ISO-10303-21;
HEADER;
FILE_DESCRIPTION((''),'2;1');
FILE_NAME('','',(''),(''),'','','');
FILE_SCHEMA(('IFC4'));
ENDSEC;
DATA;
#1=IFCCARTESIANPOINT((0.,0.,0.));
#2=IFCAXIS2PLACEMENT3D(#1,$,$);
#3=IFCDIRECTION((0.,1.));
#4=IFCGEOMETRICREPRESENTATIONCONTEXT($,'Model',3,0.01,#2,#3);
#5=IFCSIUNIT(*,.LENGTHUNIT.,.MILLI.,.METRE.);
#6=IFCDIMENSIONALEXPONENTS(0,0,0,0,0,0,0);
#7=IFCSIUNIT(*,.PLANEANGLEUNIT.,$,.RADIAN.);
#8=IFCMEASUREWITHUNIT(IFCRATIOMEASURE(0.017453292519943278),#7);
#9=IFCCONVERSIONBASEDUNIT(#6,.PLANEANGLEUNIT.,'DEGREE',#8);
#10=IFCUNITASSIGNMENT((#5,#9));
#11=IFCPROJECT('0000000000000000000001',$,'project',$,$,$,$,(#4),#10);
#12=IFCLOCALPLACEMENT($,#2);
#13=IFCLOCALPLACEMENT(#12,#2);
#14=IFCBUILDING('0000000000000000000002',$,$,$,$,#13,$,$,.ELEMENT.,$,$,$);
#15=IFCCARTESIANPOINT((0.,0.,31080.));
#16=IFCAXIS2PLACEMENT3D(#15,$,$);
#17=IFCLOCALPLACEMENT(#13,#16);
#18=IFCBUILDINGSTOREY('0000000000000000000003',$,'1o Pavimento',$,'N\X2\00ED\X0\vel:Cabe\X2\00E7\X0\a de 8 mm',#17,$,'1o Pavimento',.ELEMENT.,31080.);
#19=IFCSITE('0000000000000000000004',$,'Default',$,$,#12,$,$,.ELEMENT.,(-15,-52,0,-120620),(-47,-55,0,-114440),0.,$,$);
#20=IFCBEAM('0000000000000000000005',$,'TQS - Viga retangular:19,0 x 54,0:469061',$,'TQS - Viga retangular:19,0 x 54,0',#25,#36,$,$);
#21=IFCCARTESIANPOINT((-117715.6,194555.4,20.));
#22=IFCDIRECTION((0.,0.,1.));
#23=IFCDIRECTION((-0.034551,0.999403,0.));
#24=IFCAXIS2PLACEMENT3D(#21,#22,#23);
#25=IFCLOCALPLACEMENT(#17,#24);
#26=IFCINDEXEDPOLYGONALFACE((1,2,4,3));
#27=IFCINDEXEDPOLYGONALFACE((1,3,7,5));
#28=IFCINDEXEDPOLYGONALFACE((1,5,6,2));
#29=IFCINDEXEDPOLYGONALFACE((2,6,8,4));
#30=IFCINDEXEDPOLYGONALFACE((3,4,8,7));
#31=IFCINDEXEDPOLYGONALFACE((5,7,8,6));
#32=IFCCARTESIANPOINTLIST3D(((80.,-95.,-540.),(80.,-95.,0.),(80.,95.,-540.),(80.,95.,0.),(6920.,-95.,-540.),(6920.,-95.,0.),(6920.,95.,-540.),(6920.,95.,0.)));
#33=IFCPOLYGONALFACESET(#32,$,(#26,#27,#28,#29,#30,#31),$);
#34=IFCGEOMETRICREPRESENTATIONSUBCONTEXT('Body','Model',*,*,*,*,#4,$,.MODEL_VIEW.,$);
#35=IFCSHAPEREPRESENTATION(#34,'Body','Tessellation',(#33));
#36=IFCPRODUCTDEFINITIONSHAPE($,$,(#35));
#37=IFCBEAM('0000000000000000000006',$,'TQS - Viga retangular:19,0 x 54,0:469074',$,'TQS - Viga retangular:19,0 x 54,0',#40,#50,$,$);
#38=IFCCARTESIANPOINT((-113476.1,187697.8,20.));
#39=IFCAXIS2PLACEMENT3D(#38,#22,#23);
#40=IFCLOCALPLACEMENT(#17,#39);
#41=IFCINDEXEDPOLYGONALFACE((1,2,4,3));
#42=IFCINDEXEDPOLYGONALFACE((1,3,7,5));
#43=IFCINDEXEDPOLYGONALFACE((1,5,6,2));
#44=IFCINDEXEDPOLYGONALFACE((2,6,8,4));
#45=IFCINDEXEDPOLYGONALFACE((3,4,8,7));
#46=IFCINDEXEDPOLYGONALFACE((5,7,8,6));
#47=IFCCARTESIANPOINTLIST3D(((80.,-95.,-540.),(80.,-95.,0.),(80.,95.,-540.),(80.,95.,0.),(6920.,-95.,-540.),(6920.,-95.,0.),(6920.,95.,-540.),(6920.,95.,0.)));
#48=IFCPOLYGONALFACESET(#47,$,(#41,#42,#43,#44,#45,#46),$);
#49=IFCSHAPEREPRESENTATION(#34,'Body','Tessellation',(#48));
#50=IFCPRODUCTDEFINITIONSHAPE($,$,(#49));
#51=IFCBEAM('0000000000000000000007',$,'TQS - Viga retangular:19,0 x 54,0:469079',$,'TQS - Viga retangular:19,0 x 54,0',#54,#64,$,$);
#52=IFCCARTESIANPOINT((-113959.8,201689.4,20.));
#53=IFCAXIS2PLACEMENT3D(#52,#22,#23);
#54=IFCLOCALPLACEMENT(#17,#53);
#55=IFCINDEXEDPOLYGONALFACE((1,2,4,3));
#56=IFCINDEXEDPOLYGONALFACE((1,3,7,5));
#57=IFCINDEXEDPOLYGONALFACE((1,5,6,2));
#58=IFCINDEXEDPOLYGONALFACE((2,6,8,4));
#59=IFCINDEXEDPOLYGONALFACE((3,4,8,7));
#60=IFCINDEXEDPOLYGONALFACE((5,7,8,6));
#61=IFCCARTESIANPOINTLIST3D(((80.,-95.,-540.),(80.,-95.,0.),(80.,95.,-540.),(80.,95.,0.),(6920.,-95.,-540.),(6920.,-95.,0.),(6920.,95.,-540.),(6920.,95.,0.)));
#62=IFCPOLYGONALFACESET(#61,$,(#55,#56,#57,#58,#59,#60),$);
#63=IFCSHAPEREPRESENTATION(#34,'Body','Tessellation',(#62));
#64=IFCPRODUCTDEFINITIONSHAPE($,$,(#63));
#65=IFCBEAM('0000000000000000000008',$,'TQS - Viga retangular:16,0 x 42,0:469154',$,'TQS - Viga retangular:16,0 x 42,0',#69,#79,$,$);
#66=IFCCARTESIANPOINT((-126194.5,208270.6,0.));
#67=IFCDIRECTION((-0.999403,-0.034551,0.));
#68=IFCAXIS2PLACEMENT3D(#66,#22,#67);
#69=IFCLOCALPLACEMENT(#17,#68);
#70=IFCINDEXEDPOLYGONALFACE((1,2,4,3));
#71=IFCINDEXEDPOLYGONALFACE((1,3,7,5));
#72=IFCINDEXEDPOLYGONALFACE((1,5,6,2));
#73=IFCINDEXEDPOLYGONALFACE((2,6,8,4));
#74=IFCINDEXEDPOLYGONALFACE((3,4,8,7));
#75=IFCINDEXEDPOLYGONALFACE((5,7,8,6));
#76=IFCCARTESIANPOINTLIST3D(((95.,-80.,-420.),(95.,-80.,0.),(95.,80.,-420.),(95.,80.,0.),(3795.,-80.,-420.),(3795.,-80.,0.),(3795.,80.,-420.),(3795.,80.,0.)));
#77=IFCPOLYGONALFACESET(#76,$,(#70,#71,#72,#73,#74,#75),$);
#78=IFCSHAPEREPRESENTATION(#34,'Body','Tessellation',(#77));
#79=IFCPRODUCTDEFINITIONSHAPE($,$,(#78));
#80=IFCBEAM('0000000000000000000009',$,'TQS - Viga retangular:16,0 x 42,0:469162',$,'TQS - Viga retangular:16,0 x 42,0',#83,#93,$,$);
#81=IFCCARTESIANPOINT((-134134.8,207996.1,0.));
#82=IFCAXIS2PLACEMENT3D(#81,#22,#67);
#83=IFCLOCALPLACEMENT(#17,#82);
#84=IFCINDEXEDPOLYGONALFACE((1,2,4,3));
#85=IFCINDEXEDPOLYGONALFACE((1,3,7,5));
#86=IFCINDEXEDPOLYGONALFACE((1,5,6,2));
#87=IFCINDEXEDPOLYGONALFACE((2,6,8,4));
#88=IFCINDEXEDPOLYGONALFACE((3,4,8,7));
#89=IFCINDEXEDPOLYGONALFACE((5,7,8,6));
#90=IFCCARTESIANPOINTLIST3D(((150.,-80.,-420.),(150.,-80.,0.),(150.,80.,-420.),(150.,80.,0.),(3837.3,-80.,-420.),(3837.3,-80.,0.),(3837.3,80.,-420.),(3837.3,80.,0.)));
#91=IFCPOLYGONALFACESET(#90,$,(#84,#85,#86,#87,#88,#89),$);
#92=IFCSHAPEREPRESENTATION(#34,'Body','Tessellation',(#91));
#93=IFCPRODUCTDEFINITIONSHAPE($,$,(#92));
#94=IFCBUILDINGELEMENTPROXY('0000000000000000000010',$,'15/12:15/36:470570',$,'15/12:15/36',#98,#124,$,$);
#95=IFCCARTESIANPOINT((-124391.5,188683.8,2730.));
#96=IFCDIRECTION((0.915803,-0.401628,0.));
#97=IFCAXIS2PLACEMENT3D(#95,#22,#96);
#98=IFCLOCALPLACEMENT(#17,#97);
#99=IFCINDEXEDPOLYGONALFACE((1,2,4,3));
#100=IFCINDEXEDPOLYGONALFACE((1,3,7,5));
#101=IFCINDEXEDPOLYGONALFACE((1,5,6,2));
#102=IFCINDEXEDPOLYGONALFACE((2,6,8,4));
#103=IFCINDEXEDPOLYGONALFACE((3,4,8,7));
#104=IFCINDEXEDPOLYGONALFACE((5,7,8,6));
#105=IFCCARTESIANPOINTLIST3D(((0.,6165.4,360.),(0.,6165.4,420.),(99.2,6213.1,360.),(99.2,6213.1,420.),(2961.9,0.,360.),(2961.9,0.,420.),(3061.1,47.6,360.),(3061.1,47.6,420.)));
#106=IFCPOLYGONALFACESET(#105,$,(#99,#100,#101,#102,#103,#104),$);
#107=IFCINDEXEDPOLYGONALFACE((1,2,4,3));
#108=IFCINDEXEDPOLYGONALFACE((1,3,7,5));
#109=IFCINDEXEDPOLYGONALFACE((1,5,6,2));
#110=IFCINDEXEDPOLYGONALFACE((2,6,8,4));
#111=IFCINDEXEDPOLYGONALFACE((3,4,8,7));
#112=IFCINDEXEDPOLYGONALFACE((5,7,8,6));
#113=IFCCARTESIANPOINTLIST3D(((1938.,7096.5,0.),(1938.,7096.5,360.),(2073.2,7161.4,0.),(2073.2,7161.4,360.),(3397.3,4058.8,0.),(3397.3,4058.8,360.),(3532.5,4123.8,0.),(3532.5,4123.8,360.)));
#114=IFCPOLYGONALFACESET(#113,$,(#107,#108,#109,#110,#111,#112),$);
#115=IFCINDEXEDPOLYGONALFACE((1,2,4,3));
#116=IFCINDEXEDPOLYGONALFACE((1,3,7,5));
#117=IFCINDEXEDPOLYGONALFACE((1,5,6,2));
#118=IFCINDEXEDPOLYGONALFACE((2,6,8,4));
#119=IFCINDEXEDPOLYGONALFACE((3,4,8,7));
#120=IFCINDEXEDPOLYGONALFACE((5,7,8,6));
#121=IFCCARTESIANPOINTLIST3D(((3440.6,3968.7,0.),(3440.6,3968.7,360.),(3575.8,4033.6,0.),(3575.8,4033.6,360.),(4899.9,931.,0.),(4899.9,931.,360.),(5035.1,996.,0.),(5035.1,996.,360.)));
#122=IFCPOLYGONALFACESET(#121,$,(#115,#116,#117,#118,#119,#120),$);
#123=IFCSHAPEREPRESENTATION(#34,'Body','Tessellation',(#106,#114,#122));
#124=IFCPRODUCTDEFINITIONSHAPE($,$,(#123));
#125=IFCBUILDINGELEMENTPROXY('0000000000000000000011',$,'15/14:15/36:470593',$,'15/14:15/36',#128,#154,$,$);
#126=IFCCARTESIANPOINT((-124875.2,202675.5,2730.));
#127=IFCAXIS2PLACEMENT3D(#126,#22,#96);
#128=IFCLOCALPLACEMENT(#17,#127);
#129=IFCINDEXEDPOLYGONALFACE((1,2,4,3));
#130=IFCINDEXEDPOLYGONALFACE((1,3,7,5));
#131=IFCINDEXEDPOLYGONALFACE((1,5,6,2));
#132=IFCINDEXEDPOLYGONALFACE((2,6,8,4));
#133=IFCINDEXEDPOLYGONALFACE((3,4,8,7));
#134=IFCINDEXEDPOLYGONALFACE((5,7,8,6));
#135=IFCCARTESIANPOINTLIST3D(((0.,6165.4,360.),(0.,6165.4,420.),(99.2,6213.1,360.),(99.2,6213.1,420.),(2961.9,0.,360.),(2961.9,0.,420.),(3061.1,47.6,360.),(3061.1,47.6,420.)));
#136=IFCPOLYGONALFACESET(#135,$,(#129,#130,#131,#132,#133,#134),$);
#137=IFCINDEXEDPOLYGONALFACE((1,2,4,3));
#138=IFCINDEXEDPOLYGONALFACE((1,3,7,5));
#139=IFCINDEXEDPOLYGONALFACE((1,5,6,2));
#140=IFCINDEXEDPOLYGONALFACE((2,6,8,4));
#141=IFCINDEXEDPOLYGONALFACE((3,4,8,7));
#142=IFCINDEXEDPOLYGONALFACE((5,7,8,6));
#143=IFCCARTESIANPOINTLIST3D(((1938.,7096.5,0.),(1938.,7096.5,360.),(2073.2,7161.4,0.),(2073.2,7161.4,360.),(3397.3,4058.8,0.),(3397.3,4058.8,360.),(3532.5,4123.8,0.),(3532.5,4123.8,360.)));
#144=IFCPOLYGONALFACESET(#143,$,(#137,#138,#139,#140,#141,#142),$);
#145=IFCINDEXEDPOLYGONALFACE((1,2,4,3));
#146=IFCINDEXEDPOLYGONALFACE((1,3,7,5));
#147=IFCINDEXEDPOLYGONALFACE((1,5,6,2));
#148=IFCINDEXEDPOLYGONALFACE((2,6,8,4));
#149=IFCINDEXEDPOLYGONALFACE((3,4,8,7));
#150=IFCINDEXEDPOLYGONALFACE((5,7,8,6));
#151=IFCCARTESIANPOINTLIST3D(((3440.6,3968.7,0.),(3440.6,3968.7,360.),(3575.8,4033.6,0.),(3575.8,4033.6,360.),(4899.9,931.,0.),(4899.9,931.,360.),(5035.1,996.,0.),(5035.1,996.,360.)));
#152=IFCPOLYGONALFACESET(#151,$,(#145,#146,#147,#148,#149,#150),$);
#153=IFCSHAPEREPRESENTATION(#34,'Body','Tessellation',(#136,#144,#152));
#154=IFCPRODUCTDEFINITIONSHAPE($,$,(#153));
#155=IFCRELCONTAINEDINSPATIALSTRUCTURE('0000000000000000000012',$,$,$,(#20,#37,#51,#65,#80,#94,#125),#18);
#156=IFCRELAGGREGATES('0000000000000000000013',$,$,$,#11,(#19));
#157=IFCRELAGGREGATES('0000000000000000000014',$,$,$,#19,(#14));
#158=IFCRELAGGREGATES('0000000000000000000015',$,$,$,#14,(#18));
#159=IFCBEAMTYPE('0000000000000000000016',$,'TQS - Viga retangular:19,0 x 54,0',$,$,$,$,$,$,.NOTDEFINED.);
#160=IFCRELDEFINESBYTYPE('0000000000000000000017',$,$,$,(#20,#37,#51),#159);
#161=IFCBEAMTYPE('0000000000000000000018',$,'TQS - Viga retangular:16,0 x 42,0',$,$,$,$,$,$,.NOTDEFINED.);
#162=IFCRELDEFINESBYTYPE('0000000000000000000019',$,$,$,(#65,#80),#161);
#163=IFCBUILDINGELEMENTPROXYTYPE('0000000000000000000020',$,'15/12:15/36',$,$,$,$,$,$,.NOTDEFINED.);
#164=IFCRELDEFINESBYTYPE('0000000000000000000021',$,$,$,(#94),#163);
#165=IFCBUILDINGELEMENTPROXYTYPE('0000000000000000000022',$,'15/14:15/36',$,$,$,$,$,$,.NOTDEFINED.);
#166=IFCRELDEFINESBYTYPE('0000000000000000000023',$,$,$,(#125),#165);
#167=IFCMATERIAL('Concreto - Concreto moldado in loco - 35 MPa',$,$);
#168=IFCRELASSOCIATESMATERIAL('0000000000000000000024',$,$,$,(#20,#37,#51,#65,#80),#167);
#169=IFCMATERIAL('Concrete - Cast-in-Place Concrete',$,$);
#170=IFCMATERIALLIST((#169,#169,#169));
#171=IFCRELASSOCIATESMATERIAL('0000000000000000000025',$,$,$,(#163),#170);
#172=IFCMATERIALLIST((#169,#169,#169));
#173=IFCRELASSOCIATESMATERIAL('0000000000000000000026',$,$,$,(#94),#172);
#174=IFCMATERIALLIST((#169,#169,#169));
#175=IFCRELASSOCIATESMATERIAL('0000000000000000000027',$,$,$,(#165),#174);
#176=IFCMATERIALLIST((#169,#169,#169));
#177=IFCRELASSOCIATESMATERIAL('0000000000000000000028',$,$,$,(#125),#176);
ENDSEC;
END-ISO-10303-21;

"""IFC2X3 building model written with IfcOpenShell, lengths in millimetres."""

from ifc_helpers import new_model, entity, si_unit, converted_unit, direction, frame, frame_2d, origin, place, context, subcontext, project, spatial, rectangle, extrude, source, transform, mapped, material, material_list, type_object, type_shapes, element, save


model = new_model("IFC2X3")

# Units and contexts
model_context = context("Model", 3, precision=0.01, world=origin(), true_north=direction((0.0, 1.0)))
body_context = subcontext(model_context, "Body", "Model", "MODEL_VIEW")
ifc_project = project(units=[si_unit("LENGTHUNIT", "METRE", prefix="MILLI"), converted_unit("PLANEANGLEUNIT", "DEGREE", entity("IfcRatioMeasure", 0.017453292519943278), si_unit("PLANEANGLEUNIT", "RADIAN"), dimensions=[0, 0, 0, 0, 0, 0, 0])], contexts=[model_context])

# Site, building, storey
site_placement = place(None, origin())
site = spatial("IfcSite", under=ifc_project, at=site_placement, Name="Default", CompositionType="ELEMENT", RefLatitude=(-15, -52, 0, -120620), RefLongitude=(-47, -55, 0, -114440), RefElevation=0.0)
building_placement = place(site_placement, origin())
building = spatial("IfcBuilding", under=site, at=building_placement, CompositionType="ELEMENT")
storey_placement = place(building_placement, frame((0.0, 0.0, 31080.0)))
storey = spatial("IfcBuildingStorey", under=building, at=storey_placement, Name="1o Pavimento", ObjectType="Nível:Cabeça de 8 mm", LongName="1o Pavimento", CompositionType="ELEMENT", Elevation=31080.0)

# Beams
ifc_material_1 = material(Name="Concreto - Concreto moldado in loco - 35 MPa")
beam_type_1 = type_object("IfcBeamType", Name="TQS - Viga retangular:19,0 x 54,0", PredefinedType="NOTDEFINED")
beam_1_placement = place(storey_placement, frame((-117715.6, 194555.4, 20.0), z_axis=(0.0, 0.0, 1.0), x_axis=(-0.034551, 0.999403, 0.0)))
element("IfcBeam", 1, at=beam_1_placement, inside=storey, type_object=beam_type_1, material=ifc_material_1, Name="TQS - Viga retangular:19,0 x 54,0:469061", ObjectType="TQS - Viga retangular:19,0 x 54,0", context=body_context, shape_type="SweptSolid", body=[
    extrude(rectangle(XDim=540.0, YDim=190.0, at=frame_2d((0.0, 0.0), x_axis=(1.0, 0.0))), frame((80.0, 0.0, -270.0), z_axis=(1.0, 0.0, 0.0), x_axis=(0.0, 0.0, -1.0)), (0.0, 0.0, 1.0), 6840.0),
])
beam_2_placement = place(storey_placement, frame((-113476.1, 187697.8, 20.0), z_axis=(0.0, 0.0, 1.0), x_axis=(-0.034551, 0.999403, 0.0)))
element("IfcBeam", 2, at=beam_2_placement, inside=storey, type_object=beam_type_1, material=ifc_material_1, Name="TQS - Viga retangular:19,0 x 54,0:469074", ObjectType="TQS - Viga retangular:19,0 x 54,0", context=body_context, shape_type="SweptSolid", body=[
    extrude(rectangle(XDim=540.0, YDim=190.0, at=frame_2d((0.0, 0.0), x_axis=(1.0, 0.0))), frame((80.0, 0.0, -270.0), z_axis=(1.0, 0.0, 0.0), x_axis=(0.0, 0.0, -1.0)), (0.0, 0.0, 1.0), 6840.0),
])
beam_3_placement = place(storey_placement, frame((-113959.8, 201689.4, 20.0), z_axis=(0.0, 0.0, 1.0), x_axis=(-0.034551, 0.999403, 0.0)))
element("IfcBeam", 3, at=beam_3_placement, inside=storey, type_object=beam_type_1, material=ifc_material_1, Name="TQS - Viga retangular:19,0 x 54,0:469079", ObjectType="TQS - Viga retangular:19,0 x 54,0", context=body_context, shape_type="SweptSolid", body=[
    extrude(rectangle(XDim=540.0, YDim=190.0, at=frame_2d((0.0, 0.0), x_axis=(1.0, 0.0))), frame((80.0, 0.0, -270.0), z_axis=(1.0, 0.0, 0.0), x_axis=(0.0, 0.0, -1.0)), (0.0, 0.0, 1.0), 6840.0),
])
beam_type_2 = type_object("IfcBeamType", Name="TQS - Viga retangular:16,0 x 42,0", PredefinedType="NOTDEFINED")
beam_4_placement = place(storey_placement, frame((-126194.5, 208270.6, 0.0), z_axis=(0.0, 0.0, 1.0), x_axis=(-0.999403, -0.034551, 0.0)))
element("IfcBeam", 4, at=beam_4_placement, inside=storey, type_object=beam_type_2, material=ifc_material_1, Name="TQS - Viga retangular:16,0 x 42,0:469154", ObjectType="TQS - Viga retangular:16,0 x 42,0", context=body_context, shape_type="SweptSolid", body=[
    extrude(rectangle(XDim=420.0, YDim=160.0, at=frame_2d((0.0, 0.0), x_axis=(1.0, 0.0))), frame((95.0, 0.0, -210.0), z_axis=(1.0, 0.0, 0.0), x_axis=(0.0, 0.0, -1.0)), (0.0, 0.0, 1.0), 3700.0),
])
beam_5_placement = place(storey_placement, frame((-134134.8, 207996.1, 0.0), z_axis=(0.0, 0.0, 1.0), x_axis=(-0.999403, -0.034551, 0.0)))
element("IfcBeam", 5, at=beam_5_placement, inside=storey, type_object=beam_type_2, material=ifc_material_1, Name="TQS - Viga retangular:16,0 x 42,0:469162", ObjectType="TQS - Viga retangular:16,0 x 42,0", context=body_context, shape_type="SweptSolid", body=[
    extrude(rectangle(XDim=420.0, YDim=160.0, at=frame_2d((0.0, 0.0), x_axis=(1.0, 0.0))), frame((150.0, 0.0, -210.0), z_axis=(1.0, 0.0, 0.0), x_axis=(0.0, 0.0, -1.0)), (0.0, 0.0, 1.0), 3687.3),
])

# Building element proxies
ifc_material_2 = material(Name="Concrete - Cast-in-Place Concrete")
ifc_material_list_1 = material_list([ifc_material_2, ifc_material_2, ifc_material_2])
ifc_material_list_2 = material_list([ifc_material_2, ifc_material_2, ifc_material_2])
building_element_proxy_type_1 = type_object("IfcBuildingElementProxyType", Name="15/12:15/36", PredefinedType="NOTDEFINED", material=ifc_material_list_2)
shared_shape_1 = source(origin(), body_context, "Body", "SweptSolid", [
    extrude(rectangle(XDim=110.0, YDim=6840.0, at=frame_2d((0.0, 0.0), x_axis=(1.0, 0.0))), frame((1530.5, 3106.5, 360.0), z_axis=(0.0, 0.0, 1.0), x_axis=(0.90138, 0.43303, 0.0)), (0.0, 0.0, 1.0), 60.0),
    extrude(rectangle(XDim=3370.0, YDim=150.0, at=frame_2d((0.0, 0.0), x_axis=(1.0, 0.0))), frame((2735.2, 5610.1, 0.0), z_axis=(0.0, 0.0, 1.0), x_axis=(0.43303, -0.90138, 0.0)), (0.0, 0.0, 1.0), 360.0),
    extrude(rectangle(XDim=3370.0, YDim=150.0, at=frame_2d((0.0, 0.0), x_axis=(1.0, 0.0))), frame((4237.8, 2482.3, 0.0), z_axis=(0.0, 0.0, 1.0), x_axis=(0.43303, -0.90138, 0.0)), (0.0, 0.0, 1.0), 360.0),
])
type_shapes(building_element_proxy_type_1, [shared_shape_1])
proxy_1_placement = place(storey_placement, frame((-124391.5, 188683.8, 2730.0), z_axis=(0.0, 0.0, 1.0), x_axis=(0.915803, -0.401628, 0.0)))
element("IfcBuildingElementProxy", 6, at=proxy_1_placement, inside=storey, type_object=building_element_proxy_type_1, material=ifc_material_list_1, Name="15/12:15/36:470570", ObjectType="15/12:15/36", context=body_context, shape_type="MappedRepresentation", body=[
    mapped(shared_shape_1, transform((0.0, 0.0, 0.0), scale=1.0)),
])
ifc_material_list_3 = material_list([ifc_material_2, ifc_material_2, ifc_material_2])
ifc_material_list_4 = material_list([ifc_material_2, ifc_material_2, ifc_material_2])
building_element_proxy_type_2 = type_object("IfcBuildingElementProxyType", Name="15/14:15/36", PredefinedType="NOTDEFINED", material=ifc_material_list_4)
shared_shape_2 = source(origin(), body_context, "Body", "SweptSolid", [
    extrude(rectangle(XDim=110.0, YDim=6840.0, at=frame_2d((0.0, 0.0), x_axis=(1.0, 0.0))), frame((1530.5, 3106.5, 360.0), z_axis=(0.0, 0.0, 1.0), x_axis=(0.90138, 0.43303, 0.0)), (0.0, 0.0, 1.0), 60.0),
    extrude(rectangle(XDim=3370.0, YDim=150.0, at=frame_2d((0.0, 0.0), x_axis=(1.0, 0.0))), frame((2735.2, 5610.1, 0.0), z_axis=(0.0, 0.0, 1.0), x_axis=(0.43303, -0.90138, 0.0)), (0.0, 0.0, 1.0), 360.0),
    extrude(rectangle(XDim=3370.0, YDim=150.0, at=frame_2d((0.0, 0.0), x_axis=(1.0, 0.0))), frame((4237.8, 2482.3, 0.0), z_axis=(0.0, 0.0, 1.0), x_axis=(0.43303, -0.90138, 0.0)), (0.0, 0.0, 1.0), 360.0),
])
type_shapes(building_element_proxy_type_2, [shared_shape_2])
proxy_2_placement = place(storey_placement, frame((-124875.2, 202675.5, 2730.0), z_axis=(0.0, 0.0, 1.0), x_axis=(0.915803, -0.401628, 0.0)))
element("IfcBuildingElementProxy", 7, at=proxy_2_placement, inside=storey, type_object=building_element_proxy_type_2, material=ifc_material_list_3, Name="15/14:15/36:470593", ObjectType="15/14:15/36", context=body_context, shape_type="MappedRepresentation", body=[
    mapped(shared_shape_2, transform((0.0, 0.0, 0.0), scale=1.0)),
])

save(model, "model.ifc")
